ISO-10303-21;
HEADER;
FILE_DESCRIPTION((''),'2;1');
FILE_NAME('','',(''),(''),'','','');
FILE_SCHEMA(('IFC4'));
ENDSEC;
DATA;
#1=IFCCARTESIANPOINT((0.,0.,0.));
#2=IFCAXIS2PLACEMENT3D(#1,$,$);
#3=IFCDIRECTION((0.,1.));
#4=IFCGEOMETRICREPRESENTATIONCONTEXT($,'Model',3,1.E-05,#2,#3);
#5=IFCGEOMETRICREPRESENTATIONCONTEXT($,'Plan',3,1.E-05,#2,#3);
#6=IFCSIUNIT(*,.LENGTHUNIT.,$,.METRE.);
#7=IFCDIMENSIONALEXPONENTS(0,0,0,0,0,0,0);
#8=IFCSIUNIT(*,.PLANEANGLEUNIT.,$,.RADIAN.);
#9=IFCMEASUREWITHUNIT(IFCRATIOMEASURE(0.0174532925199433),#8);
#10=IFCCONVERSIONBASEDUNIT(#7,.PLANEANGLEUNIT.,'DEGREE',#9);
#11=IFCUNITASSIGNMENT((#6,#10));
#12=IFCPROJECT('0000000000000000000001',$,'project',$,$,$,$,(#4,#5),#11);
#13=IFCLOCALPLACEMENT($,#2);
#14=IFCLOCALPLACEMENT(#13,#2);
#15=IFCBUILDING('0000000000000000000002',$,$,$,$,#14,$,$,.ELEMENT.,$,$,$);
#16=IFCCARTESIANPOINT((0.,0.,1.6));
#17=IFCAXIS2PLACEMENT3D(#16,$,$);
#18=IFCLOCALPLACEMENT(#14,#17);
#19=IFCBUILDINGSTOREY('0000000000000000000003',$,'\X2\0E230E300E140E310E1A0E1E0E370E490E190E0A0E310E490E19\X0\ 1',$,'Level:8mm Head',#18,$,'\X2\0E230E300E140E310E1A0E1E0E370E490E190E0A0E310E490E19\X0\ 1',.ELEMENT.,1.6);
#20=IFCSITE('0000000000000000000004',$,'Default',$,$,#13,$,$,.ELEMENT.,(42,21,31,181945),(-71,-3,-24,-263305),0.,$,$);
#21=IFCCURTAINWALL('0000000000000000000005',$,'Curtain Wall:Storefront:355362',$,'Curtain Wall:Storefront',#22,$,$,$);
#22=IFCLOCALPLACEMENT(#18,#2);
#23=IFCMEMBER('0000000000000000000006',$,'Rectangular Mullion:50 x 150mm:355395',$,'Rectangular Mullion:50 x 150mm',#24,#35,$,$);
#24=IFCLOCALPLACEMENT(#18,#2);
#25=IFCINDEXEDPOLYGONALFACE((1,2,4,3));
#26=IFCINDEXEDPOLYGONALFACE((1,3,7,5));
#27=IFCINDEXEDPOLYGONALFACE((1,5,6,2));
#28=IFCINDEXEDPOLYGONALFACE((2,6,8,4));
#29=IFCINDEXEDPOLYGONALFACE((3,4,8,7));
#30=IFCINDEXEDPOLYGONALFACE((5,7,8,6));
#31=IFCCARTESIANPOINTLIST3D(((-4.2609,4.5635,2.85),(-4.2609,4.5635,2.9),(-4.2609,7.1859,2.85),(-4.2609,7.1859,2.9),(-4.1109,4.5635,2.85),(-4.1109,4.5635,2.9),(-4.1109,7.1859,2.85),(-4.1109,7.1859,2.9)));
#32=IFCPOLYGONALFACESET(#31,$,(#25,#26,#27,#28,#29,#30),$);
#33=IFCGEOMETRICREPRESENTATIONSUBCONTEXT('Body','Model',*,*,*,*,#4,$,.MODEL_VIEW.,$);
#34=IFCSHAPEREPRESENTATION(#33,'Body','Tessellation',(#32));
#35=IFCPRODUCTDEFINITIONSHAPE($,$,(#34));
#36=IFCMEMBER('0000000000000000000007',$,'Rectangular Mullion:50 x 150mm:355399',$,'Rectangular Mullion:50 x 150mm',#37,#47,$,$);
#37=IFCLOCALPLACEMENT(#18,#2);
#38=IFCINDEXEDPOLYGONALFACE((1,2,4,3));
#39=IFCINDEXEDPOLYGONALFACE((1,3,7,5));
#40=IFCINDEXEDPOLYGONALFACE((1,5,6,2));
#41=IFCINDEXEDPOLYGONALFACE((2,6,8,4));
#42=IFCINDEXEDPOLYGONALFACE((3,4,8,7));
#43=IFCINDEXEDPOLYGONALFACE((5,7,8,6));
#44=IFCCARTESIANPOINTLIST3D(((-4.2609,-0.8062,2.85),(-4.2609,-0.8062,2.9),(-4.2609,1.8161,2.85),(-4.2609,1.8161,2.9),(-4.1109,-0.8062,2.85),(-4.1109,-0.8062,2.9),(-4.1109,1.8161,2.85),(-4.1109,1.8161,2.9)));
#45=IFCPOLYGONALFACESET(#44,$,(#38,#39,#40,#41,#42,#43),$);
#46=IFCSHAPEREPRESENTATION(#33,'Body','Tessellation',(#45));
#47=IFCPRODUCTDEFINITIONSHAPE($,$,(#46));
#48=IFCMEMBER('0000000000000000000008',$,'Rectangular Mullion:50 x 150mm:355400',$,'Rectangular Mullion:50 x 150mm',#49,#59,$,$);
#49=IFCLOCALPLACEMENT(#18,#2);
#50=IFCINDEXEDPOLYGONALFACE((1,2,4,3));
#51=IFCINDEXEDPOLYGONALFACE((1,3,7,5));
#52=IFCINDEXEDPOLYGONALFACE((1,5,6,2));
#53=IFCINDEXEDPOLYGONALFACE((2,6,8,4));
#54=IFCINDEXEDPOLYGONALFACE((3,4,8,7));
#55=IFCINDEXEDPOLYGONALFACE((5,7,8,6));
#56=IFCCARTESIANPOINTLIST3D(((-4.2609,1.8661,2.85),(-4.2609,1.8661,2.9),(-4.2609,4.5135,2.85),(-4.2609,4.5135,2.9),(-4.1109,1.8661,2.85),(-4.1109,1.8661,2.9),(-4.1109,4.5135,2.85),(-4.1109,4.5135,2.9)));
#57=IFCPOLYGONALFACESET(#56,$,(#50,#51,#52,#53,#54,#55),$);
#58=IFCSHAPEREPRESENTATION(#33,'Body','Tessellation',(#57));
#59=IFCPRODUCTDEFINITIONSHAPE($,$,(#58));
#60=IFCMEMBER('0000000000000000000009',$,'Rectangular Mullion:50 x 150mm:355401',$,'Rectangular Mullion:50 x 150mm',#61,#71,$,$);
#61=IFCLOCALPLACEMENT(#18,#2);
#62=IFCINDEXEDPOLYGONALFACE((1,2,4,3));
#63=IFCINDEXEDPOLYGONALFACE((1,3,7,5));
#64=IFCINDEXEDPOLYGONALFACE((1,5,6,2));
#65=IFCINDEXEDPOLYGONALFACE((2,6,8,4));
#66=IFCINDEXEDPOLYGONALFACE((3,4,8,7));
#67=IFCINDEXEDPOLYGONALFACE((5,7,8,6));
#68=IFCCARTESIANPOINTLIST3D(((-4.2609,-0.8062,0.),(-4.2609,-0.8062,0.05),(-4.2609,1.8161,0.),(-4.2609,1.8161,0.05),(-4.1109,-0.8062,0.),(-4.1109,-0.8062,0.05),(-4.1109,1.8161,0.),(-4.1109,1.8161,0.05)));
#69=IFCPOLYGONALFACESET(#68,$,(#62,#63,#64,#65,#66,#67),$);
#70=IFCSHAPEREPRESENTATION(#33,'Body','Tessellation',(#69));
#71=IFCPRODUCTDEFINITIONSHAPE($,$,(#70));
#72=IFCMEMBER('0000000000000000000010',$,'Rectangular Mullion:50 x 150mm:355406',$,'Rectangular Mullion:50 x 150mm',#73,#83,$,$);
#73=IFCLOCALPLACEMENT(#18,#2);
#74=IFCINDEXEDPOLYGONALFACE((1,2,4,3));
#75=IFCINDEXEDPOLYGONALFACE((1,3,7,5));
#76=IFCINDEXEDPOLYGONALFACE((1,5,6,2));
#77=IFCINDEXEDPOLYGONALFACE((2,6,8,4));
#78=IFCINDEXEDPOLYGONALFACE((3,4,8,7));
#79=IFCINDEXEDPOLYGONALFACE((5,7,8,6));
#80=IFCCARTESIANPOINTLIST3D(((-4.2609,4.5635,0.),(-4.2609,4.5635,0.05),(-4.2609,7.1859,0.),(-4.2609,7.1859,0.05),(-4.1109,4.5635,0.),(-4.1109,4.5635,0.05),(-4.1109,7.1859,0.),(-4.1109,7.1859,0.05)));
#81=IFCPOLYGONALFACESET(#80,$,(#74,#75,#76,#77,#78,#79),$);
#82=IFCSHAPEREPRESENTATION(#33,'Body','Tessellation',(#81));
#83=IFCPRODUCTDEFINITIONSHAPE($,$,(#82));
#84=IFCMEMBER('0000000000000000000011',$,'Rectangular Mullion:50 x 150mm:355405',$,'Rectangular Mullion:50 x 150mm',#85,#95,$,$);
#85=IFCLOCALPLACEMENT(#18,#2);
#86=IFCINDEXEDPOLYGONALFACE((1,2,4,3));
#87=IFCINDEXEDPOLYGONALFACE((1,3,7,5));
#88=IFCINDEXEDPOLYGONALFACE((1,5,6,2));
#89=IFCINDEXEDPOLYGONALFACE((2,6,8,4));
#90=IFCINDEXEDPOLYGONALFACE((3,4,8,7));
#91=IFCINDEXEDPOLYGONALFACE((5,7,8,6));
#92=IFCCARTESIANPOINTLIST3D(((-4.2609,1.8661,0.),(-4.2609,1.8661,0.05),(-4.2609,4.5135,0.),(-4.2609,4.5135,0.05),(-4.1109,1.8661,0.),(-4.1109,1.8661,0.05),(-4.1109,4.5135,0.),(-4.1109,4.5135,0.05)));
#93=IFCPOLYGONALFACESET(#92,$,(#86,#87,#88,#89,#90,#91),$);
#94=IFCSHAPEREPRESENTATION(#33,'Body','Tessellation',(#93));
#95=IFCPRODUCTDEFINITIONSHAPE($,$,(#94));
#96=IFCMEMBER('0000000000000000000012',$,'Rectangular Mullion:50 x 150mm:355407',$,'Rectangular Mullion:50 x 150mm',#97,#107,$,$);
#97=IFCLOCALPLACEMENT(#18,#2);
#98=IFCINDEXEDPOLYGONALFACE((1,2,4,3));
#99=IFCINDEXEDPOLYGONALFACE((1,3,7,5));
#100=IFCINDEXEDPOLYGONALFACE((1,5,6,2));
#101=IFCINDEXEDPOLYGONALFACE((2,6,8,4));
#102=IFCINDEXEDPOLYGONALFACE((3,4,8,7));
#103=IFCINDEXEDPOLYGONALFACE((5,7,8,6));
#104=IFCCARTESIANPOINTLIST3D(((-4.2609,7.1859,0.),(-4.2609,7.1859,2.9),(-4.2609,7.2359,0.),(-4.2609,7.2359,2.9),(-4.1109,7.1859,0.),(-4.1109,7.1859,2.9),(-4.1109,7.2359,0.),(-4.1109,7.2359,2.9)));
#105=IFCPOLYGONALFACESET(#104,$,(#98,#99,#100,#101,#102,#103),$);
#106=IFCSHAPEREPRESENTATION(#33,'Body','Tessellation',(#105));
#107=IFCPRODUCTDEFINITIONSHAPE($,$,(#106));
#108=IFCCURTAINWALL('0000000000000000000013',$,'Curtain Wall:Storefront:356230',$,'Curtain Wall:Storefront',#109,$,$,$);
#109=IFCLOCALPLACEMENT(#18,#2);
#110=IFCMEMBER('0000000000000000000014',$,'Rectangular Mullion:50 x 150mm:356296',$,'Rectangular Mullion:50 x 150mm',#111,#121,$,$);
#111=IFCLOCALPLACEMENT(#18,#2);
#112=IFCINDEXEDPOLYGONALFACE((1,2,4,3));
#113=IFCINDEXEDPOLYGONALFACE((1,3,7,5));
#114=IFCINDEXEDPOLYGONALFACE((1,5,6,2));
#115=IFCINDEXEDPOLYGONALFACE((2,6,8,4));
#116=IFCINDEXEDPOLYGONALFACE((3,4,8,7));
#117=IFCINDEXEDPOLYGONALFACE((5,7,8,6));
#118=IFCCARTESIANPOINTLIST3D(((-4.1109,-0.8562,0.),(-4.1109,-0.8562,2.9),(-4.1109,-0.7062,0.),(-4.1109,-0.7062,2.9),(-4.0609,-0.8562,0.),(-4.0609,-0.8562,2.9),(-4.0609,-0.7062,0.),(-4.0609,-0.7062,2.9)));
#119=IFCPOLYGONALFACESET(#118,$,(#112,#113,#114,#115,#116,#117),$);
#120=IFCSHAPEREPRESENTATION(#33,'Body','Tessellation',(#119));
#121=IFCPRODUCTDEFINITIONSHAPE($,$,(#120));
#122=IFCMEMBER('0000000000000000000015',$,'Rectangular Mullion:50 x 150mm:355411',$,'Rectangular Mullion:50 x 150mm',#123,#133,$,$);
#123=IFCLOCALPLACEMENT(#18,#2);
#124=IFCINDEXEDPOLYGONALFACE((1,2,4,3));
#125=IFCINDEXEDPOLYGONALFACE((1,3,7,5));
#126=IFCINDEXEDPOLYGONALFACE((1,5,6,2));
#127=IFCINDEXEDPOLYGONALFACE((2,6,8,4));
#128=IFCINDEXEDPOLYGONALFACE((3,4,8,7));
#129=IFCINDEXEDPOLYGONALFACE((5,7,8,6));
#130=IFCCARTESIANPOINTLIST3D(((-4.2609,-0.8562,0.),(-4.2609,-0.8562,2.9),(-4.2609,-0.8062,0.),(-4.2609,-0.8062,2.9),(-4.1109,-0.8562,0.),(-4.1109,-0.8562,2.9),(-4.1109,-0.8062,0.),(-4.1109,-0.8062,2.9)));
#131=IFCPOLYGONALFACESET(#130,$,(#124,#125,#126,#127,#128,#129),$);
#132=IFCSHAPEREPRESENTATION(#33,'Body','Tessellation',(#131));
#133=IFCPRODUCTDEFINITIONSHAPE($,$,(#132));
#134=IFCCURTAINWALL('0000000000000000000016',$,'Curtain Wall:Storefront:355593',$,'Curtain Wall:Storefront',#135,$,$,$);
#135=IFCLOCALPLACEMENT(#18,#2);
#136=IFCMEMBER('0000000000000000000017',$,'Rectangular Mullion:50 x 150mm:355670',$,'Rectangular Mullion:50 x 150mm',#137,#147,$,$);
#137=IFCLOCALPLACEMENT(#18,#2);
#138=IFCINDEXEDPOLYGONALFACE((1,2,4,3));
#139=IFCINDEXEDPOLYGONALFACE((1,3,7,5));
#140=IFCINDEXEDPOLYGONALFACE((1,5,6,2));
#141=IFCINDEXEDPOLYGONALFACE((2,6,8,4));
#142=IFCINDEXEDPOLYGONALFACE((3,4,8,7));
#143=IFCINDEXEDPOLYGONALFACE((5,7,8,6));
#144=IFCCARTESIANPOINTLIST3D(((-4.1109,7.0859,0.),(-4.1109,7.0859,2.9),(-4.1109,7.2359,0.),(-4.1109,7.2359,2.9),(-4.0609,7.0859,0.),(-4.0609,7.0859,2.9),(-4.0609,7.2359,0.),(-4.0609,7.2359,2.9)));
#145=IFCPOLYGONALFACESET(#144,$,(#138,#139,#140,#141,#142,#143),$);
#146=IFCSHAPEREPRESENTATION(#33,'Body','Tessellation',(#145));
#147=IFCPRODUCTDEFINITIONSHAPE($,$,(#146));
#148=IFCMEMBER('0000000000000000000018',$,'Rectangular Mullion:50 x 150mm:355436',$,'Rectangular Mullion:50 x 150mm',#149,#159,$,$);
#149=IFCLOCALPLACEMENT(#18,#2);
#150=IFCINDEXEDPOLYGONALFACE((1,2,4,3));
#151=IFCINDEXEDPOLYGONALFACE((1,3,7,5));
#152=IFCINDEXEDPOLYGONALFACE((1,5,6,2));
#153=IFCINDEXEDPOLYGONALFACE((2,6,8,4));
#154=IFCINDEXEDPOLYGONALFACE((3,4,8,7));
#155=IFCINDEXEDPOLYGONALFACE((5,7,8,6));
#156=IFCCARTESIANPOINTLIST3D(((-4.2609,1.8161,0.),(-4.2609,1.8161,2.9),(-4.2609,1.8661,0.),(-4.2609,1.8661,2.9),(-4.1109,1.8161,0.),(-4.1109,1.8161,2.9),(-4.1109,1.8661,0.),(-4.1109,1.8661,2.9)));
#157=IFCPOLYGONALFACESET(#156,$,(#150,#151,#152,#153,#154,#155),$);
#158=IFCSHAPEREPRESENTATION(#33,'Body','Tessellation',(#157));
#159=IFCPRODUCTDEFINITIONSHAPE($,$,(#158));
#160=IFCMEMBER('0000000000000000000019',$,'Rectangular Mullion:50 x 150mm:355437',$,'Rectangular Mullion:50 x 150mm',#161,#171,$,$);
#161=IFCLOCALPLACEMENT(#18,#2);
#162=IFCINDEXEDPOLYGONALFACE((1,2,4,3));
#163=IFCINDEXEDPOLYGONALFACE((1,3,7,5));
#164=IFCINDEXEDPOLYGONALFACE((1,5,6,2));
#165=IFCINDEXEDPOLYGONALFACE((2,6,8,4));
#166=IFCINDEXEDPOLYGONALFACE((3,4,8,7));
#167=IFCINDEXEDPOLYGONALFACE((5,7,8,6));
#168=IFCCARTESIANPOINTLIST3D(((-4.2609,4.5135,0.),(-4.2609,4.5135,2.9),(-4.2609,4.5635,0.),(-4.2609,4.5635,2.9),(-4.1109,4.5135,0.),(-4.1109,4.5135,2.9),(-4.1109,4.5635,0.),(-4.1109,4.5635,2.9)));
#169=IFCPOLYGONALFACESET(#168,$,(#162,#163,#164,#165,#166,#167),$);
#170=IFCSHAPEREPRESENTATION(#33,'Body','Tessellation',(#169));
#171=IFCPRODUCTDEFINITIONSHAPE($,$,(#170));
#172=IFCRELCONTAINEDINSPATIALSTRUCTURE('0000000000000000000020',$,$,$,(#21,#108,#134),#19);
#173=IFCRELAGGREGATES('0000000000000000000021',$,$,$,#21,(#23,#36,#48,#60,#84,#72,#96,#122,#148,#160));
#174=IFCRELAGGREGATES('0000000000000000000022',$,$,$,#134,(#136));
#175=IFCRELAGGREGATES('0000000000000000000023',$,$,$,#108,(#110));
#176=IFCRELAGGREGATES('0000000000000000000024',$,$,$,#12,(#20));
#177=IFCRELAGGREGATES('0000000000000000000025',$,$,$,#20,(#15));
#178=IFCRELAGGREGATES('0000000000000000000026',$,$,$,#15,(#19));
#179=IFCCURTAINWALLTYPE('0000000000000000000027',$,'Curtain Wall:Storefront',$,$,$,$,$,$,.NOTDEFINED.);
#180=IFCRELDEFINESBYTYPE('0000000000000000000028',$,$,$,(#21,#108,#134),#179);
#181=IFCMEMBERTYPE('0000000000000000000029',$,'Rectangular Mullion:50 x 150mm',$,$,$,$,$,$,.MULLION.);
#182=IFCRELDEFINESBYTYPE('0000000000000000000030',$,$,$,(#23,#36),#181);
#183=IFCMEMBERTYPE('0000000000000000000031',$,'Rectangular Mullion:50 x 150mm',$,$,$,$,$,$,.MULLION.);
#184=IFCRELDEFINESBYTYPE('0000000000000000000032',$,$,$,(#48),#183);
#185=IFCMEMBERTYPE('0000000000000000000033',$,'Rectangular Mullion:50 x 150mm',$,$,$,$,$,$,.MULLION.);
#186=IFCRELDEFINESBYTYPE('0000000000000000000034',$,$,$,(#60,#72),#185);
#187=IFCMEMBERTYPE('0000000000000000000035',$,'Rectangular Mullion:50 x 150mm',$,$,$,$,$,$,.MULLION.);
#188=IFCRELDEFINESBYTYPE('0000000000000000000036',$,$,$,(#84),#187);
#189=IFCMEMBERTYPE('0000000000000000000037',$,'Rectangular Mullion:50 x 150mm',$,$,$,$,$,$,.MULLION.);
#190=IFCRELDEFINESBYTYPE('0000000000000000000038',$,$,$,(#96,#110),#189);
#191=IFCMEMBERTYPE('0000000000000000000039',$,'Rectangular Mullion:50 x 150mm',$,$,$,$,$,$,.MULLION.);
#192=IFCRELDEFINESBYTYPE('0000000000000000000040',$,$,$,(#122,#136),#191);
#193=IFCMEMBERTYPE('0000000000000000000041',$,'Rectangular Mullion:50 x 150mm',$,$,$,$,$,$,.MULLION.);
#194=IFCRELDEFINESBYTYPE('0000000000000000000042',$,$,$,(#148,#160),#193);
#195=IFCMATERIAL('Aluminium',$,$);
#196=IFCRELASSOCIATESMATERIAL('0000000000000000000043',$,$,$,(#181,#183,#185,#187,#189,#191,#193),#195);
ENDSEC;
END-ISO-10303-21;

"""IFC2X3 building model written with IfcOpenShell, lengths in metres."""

from ifc_helpers import new_model, entity, si_unit, converted_unit, direction, frame, origin, origin_2d_with_axis, place, context, subcontext, project, spatial, rectangle, extrude, source, transform, mapped, material, type_object, type_shapes, element, aggregate, save


model = new_model("IFC2X3")

# Units and contexts
model_context = context("Model", 3, precision=1e-05, world=origin(), true_north=direction((0.0, 1.0)))
plan_context = context("Plan", 3, precision=1e-05, world=origin(), true_north=direction((0.0, 1.0)))
body_context = subcontext(model_context, "Body", "Model", "MODEL_VIEW")
ifc_project = project(units=[si_unit("LENGTHUNIT", "METRE"), converted_unit("PLANEANGLEUNIT", "DEGREE", entity("IfcRatioMeasure", 0.0174532925199433), si_unit("PLANEANGLEUNIT", "RADIAN"), dimensions=[0, 0, 0, 0, 0, 0, 0])], contexts=[model_context, plan_context])

# Site, building, storey
site_placement = place(None, origin())
site = spatial("IfcSite", under=ifc_project, at=site_placement, Name="Default", CompositionType="ELEMENT", RefLatitude=(42, 21, 31, 181945), RefLongitude=(-71, -3, -24, -263305), RefElevation=0.0)
building_placement = place(site_placement, origin())
building = spatial("IfcBuilding", under=site, at=building_placement, CompositionType="ELEMENT")
storey_placement = place(building_placement, frame((0.0, 0.0, 1.6)))
storey = spatial("IfcBuildingStorey", under=building, at=storey_placement, Name="ระดับพื้นชั้น 1", ObjectType="Level:8mm Head", LongName="ระดับพื้นชั้น 1", CompositionType="ELEMENT", Elevation=1.6)

# Curtain wall, members
curtain_wall_type = type_object("IfcCurtainWallType", Name="Curtain Wall:Storefront", PredefinedType="NOTDEFINED")
curtain_wall_1_placement = place(storey_placement, frame((0.0, 0.0, -1.6)))
curtain_wall_1 = element("IfcCurtainWall", 1, at=curtain_wall_1_placement, inside=storey, type_object=curtain_wall_type, Name="Curtain Wall:Storefront:355362", ObjectType="Curtain Wall:Storefront")
ifc_material_1 = material(Name="Aluminium")
member_type_1 = type_object("IfcMemberType", Name="Rectangular Mullion:50 x 150mm", PredefinedType="MULLION", material=ifc_material_1)
shared_shape_1 = source(origin(), body_context, "Body", "SweptSolid", [
    extrude(rectangle(XDim=0.15, YDim=0.05, at=origin_2d_with_axis()), frame((-0.025, 0.0, -2.6224), z_axis=(0.0, 0.0, 1.0), x_axis=(0.0, -1.0, 0.0)), (0.0, 0.0, 1.0), 2.6224),
])
type_shapes(member_type_1, [shared_shape_1])
member_1_placement = place(curtain_wall_1_placement, frame((-4.1859, 7.1859, 4.5), z_axis=(0.0, 1.0, 0.0), x_axis=(0.0, 0.0, 1.0)))
member_1 = element("IfcMember", 2, at=member_1_placement, type_object=member_type_1, Name="Rectangular Mullion:50 x 150mm:355395", ObjectType="Rectangular Mullion:50 x 150mm", context=body_context, shape_type="MappedRepresentation", body=[
    mapped(shared_shape_1, transform((0.0, 0.0, 0.0), scale=1.0)),
])
member_2_placement = place(curtain_wall_1_placement, frame((-4.1859, 1.8161, 4.5), z_axis=(0.0, 1.0, 0.0), x_axis=(0.0, 0.0, 1.0)))
member_2 = element("IfcMember", 3, at=member_2_placement, type_object=member_type_1, Name="Rectangular Mullion:50 x 150mm:355399", ObjectType="Rectangular Mullion:50 x 150mm", context=body_context, shape_type="MappedRepresentation", body=[
    mapped(shared_shape_1, transform((0.0, 0.0, 0.0), scale=1.0)),
])
member_type_2 = type_object("IfcMemberType", Name="Rectangular Mullion:50 x 150mm", PredefinedType="MULLION", material=ifc_material_1)
shared_shape_2 = source(origin(), body_context, "Body", "SweptSolid", [
    extrude(rectangle(XDim=0.15, YDim=0.05, at=origin_2d_with_axis()), frame((-0.025, 0.0, -2.6474), z_axis=(0.0, 0.0, 1.0), x_axis=(0.0, -1.0, 0.0)), (0.0, 0.0, 1.0), 2.6474),
])
type_shapes(member_type_2, [shared_shape_2])
member_3_placement = place(curtain_wall_1_placement, frame((-4.1859, 4.5135, 4.5), z_axis=(0.0, 1.0, 0.0), x_axis=(0.0, 0.0, 1.0)))
member_3 = element("IfcMember", 4, at=member_3_placement, type_object=member_type_2, Name="Rectangular Mullion:50 x 150mm:355400", ObjectType="Rectangular Mullion:50 x 150mm", context=body_context, shape_type="MappedRepresentation", body=[
    mapped(shared_shape_2, transform((0.0, 0.0, 0.0), scale=1.0)),
])
member_type_3 = type_object("IfcMemberType", Name="Rectangular Mullion:50 x 150mm", PredefinedType="MULLION", material=ifc_material_1)
shared_shape_3 = source(origin(), body_context, "Body", "SweptSolid", [
    extrude(rectangle(XDim=0.15, YDim=0.05, at=origin_2d_with_axis()), frame((-0.025, 0.0, -2.6224), z_axis=(0.0, 0.0, 1.0), x_axis=(0.0, -1.0, 0.0)), (0.0, 0.0, 1.0), 2.6224),
])
type_shapes(member_type_3, [shared_shape_3])
member_4_placement = place(curtain_wall_1_placement, frame((-4.1859, -0.8062, 1.6), z_axis=(0.0, -1.0, 0.0), x_axis=(0.0, 0.0, -1.0)))
member_4 = element("IfcMember", 5, at=member_4_placement, type_object=member_type_3, Name="Rectangular Mullion:50 x 150mm:355401", ObjectType="Rectangular Mullion:50 x 150mm", context=body_context, shape_type="MappedRepresentation", body=[
    mapped(shared_shape_3, transform((0.0, 0.0, 0.0), scale=1.0)),
])
member_5_placement = place(curtain_wall_1_placement, frame((-4.1859, 4.5635, 1.6), z_axis=(0.0, -1.0, 0.0), x_axis=(0.0, 0.0, -1.0)))
member_5 = element("IfcMember", 6, at=member_5_placement, type_object=member_type_3, Name="Rectangular Mullion:50 x 150mm:355406", ObjectType="Rectangular Mullion:50 x 150mm", context=body_context, shape_type="MappedRepresentation", body=[
    mapped(shared_shape_3, transform((0.0, 0.0, 0.0), scale=1.0)),
])
member_type_4 = type_object("IfcMemberType", Name="Rectangular Mullion:50 x 150mm", PredefinedType="MULLION", material=ifc_material_1)
shared_shape_4 = source(origin(), body_context, "Body", "SweptSolid", [
    extrude(rectangle(XDim=0.15, YDim=0.05, at=origin_2d_with_axis()), frame((-0.025, 0.0, -2.6474), z_axis=(0.0, 0.0, 1.0), x_axis=(0.0, -1.0, 0.0)), (0.0, 0.0, 1.0), 2.6474),
])
type_shapes(member_type_4, [shared_shape_4])
member_6_placement = place(curtain_wall_1_placement, frame((-4.1859, 1.8661, 1.6), z_axis=(0.0, -1.0, 0.0), x_axis=(0.0, 0.0, -1.0)))
member_6 = element("IfcMember", 7, at=member_6_placement, type_object=member_type_4, Name="Rectangular Mullion:50 x 150mm:355405", ObjectType="Rectangular Mullion:50 x 150mm", context=body_context, shape_type="MappedRepresentation", body=[
    mapped(shared_shape_4, transform((0.0, 0.0, 0.0), scale=1.0)),
])
member_type_5 = type_object("IfcMemberType", Name="Rectangular Mullion:50 x 150mm", PredefinedType="MULLION", material=ifc_material_1)
shared_shape_5 = source(origin(), body_context, "Body", "SweptSolid", [
    extrude(rectangle(XDim=0.15, YDim=0.05, at=origin_2d_with_axis()), frame((-0.025, 0.0, -2.9), z_axis=(0.0, 0.0, 1.0), x_axis=(0.0, -1.0, 0.0)), (0.0, 0.0, 1.0), 2.9),
])
type_shapes(member_type_5, [shared_shape_5])
member_7_placement = place(curtain_wall_1_placement, frame((-4.1859, 7.2359, 1.6), z_axis=(0.0, 0.0, -1.0), x_axis=(0.0, 1.0, 0.0)))
member_7 = element("IfcMember", 8, at=member_7_placement, type_object=member_type_5, Name="Rectangular Mullion:50 x 150mm:355407", ObjectType="Rectangular Mullion:50 x 150mm", context=body_context, shape_type="MappedRepresentation", body=[
    mapped(shared_shape_5, transform((0.0, 0.0, 0.0), scale=1.0)),
])

# Curtain wall, member
curtain_wall_2_placement = place(storey_placement, frame((0.0, 0.0, -1.6)))
curtain_wall_2 = element("IfcCurtainWall", 9, at=curtain_wall_2_placement, inside=storey, type_object=curtain_wall_type, Name="Curtain Wall:Storefront:356230", ObjectType="Curtain Wall:Storefront")
member_8_placement = place(curtain_wall_2_placement, frame((-4.1109, -0.7812, 1.6), z_axis=(0.0, 0.0, -1.0), x_axis=(-1.0, 0.0, 0.0)))
member_8 = element("IfcMember", 10, at=member_8_placement, type_object=member_type_5, Name="Rectangular Mullion:50 x 150mm:356296", ObjectType="Rectangular Mullion:50 x 150mm", context=body_context, shape_type="MappedRepresentation", body=[
    mapped(shared_shape_5, transform((0.0, 0.0, 0.0), scale=1.0)),
])

# Member
member_type_6 = type_object("IfcMemberType", Name="Rectangular Mullion:50 x 150mm", PredefinedType="MULLION", material=ifc_material_1)
shared_shape_6 = source(origin(), body_context, "Body", "SweptSolid", [
    extrude(rectangle(XDim=0.15, YDim=0.05, at=origin_2d_with_axis()), frame((-0.025, 0.0, -2.9), z_axis=(0.0, 0.0, 1.0), x_axis=(0.0, -1.0, 0.0)), (0.0, 0.0, 1.0), 2.9),
])
type_shapes(member_type_6, [shared_shape_6])
member_9_placement = place(curtain_wall_1_placement, frame((-4.1859, -0.8562, 4.5), z_axis=(0.0, 0.0, 1.0), x_axis=(0.0, -1.0, 0.0)))
member_9 = element("IfcMember", 11, at=member_9_placement, type_object=member_type_6, Name="Rectangular Mullion:50 x 150mm:355411", ObjectType="Rectangular Mullion:50 x 150mm", context=body_context, shape_type="MappedRepresentation", body=[
    mapped(shared_shape_6, transform((0.0, 0.0, 0.0), scale=1.0)),
])

# Curtain wall, member
curtain_wall_3_placement = place(storey_placement, frame((0.0, 0.0, -1.6)))
curtain_wall_3 = element("IfcCurtainWall", 12, at=curtain_wall_3_placement, inside=storey, type_object=curtain_wall_type, Name="Curtain Wall:Storefront:355593", ObjectType="Curtain Wall:Storefront")
member_10_placement = place(curtain_wall_3_placement, frame((-4.1109, 7.1609, 4.5), z_axis=(0.0, 0.0, 1.0), x_axis=(-1.0, 0.0, 0.0)))
member_10 = element("IfcMember", 13, at=member_10_placement, type_object=member_type_6, Name="Rectangular Mullion:50 x 150mm:355670", ObjectType="Rectangular Mullion:50 x 150mm", context=body_context, shape_type="MappedRepresentation", body=[
    mapped(shared_shape_6, transform((0.0, 0.0, 0.0), scale=1.0)),
])

# Members
member_type_7 = type_object("IfcMemberType", Name="Rectangular Mullion:50 x 150mm", PredefinedType="MULLION", material=ifc_material_1)
shared_shape_7 = source(origin(), body_context, "Body", "SweptSolid", [
    extrude(rectangle(XDim=0.15, YDim=0.05, at=origin_2d_with_axis()), frame((0.0, 0.0, -2.9), z_axis=(0.0, 0.0, 1.0), x_axis=(0.0, -1.0, 0.0)), (0.0, 0.0, 1.0), 2.9),
])
type_shapes(member_type_7, [shared_shape_7])
member_11_placement = place(curtain_wall_1_placement, frame((-4.1859, 1.8411, 1.6), z_axis=(0.0, 0.0, -1.0), x_axis=(0.0, 1.0, 0.0)))
member_11 = element("IfcMember", 14, at=member_11_placement, type_object=member_type_7, Name="Rectangular Mullion:50 x 150mm:355436", ObjectType="Rectangular Mullion:50 x 150mm", context=body_context, shape_type="MappedRepresentation", body=[
    mapped(shared_shape_7, transform((0.0, 0.0, 0.0), scale=1.0)),
])
member_12_placement = place(curtain_wall_1_placement, frame((-4.1859, 4.5385, 1.6), z_axis=(0.0, 0.0, -1.0), x_axis=(0.0, 1.0, 0.0)))
member_12 = element("IfcMember", 15, at=member_12_placement, type_object=member_type_7, Name="Rectangular Mullion:50 x 150mm:355437", ObjectType="Rectangular Mullion:50 x 150mm", context=body_context, shape_type="MappedRepresentation", body=[
    mapped(shared_shape_7, transform((0.0, 0.0, 0.0), scale=1.0)),
])

aggregate(curtain_wall_1, [member_1, member_2, member_3, member_4, member_6, member_5, member_7, member_9, member_11, member_12])
aggregate(curtain_wall_3, [member_10])
aggregate(curtain_wall_2, [member_8])

save(model, "model.ifc")
